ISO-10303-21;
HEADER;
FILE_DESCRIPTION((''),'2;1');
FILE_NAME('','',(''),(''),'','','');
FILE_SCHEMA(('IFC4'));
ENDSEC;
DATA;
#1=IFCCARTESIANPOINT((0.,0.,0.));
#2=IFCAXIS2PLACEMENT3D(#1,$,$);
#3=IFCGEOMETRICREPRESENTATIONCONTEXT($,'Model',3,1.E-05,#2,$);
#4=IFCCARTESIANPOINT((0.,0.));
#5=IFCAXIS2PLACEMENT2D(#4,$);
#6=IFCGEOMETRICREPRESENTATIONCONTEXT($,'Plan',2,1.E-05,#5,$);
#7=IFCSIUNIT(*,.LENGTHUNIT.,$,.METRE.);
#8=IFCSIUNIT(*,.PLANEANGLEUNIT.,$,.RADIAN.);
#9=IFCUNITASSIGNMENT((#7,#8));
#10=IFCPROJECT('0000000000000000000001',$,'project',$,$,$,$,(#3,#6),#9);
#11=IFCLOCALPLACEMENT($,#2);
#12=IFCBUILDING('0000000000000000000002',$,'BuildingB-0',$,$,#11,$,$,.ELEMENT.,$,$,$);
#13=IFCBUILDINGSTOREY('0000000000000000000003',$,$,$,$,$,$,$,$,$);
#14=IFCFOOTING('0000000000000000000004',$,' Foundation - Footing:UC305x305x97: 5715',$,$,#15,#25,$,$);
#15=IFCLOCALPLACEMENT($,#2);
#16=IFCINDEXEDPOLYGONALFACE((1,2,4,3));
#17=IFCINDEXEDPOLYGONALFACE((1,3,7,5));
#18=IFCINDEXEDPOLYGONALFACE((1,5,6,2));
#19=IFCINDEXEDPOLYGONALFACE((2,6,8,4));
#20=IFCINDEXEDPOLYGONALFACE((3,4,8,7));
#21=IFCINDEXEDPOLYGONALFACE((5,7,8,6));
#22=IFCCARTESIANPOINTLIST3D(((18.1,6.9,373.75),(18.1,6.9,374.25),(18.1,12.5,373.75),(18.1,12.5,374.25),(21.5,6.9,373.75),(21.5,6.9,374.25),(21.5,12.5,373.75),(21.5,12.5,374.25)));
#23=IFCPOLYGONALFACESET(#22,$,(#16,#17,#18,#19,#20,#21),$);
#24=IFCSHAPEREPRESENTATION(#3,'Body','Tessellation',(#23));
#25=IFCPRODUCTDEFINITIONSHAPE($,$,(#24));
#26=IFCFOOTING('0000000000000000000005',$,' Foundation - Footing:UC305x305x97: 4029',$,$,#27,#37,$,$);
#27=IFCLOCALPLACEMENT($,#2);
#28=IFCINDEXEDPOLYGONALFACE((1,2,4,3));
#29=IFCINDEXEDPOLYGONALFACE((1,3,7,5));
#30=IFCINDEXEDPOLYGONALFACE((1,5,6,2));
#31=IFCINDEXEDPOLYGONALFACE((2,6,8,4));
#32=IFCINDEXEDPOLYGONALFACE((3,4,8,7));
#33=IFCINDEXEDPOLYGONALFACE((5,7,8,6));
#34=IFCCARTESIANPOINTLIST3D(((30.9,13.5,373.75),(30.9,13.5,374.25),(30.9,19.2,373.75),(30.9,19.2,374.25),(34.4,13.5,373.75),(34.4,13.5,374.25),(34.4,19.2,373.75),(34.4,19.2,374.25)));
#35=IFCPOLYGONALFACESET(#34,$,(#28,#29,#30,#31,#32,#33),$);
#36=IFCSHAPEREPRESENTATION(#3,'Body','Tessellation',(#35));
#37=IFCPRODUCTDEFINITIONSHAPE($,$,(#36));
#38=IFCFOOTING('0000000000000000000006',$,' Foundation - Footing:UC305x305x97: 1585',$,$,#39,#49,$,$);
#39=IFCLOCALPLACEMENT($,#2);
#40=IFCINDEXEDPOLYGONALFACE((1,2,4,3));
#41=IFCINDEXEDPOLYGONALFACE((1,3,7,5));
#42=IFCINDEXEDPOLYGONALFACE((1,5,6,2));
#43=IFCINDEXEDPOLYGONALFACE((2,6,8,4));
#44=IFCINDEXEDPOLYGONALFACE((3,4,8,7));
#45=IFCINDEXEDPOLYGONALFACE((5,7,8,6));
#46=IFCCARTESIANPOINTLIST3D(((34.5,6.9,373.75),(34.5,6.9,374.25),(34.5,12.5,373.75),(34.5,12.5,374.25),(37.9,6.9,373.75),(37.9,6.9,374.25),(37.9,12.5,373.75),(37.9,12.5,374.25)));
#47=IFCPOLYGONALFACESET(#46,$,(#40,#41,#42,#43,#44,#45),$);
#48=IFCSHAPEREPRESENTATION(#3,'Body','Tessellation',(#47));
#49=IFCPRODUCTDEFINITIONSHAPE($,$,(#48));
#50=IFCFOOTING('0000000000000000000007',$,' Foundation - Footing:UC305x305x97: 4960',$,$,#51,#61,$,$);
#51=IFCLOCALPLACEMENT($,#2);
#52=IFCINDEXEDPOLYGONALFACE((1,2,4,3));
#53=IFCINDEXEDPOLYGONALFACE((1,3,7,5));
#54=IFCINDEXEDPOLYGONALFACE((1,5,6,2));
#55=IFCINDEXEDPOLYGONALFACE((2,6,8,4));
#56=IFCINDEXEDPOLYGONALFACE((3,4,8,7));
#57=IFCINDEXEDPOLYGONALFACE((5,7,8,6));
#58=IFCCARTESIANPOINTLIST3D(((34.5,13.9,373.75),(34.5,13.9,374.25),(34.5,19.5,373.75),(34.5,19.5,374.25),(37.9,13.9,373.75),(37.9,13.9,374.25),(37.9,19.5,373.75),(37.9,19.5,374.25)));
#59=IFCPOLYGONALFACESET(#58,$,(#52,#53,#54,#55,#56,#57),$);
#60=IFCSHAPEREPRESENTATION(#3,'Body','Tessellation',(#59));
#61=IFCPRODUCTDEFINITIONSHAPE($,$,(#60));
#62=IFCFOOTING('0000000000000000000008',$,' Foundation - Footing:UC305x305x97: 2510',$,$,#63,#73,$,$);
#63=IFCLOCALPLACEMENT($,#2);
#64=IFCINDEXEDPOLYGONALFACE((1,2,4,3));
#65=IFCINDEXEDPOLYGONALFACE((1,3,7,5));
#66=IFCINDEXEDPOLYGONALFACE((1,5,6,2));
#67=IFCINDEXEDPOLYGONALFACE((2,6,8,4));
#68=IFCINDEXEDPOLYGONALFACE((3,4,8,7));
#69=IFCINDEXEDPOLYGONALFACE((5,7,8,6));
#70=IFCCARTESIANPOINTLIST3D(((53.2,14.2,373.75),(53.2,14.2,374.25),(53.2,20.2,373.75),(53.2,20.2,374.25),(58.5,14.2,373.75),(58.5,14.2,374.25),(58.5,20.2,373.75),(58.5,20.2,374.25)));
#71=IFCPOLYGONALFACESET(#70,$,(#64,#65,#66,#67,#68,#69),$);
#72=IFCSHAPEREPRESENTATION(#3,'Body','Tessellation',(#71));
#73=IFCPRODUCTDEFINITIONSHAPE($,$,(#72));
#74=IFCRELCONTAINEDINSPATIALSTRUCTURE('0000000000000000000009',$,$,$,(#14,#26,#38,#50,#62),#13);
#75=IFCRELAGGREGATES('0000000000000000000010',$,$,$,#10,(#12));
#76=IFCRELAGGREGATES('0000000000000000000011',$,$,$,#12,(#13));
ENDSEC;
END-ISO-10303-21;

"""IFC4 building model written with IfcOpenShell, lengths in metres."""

from ifc_helpers import new_model, si_unit, origin, origin_2d, place, context, project, spatial, polyline, outline, extrude, element, save


model = new_model("IFC4")

# Units and contexts
model_context = context("Model", 3, precision=1e-05, world=origin())
plan_context = context("Plan", 2, precision=1e-05, world=origin_2d())
ifc_project = project(units=[si_unit("LENGTHUNIT", "METRE"), si_unit("PLANEANGLEUNIT", "RADIAN")], contexts=[model_context, plan_context])

# Building, storey
building_placement = place(None, origin())
building = spatial("IfcBuilding", under=ifc_project, at=building_placement, Name="BuildingB-0", CompositionType="ELEMENT")
storey = spatial("IfcBuildingStorey", under=building)

# Footings
element("IfcFooting", 1, inside=storey, Name=" Foundation - Footing:UC305x305x97: 5715", context=model_context, shape_type="SweptSolid", body=[
    extrude(outline(polyline([(21.5, 12.5, 373.75), (18.1, 12.5, 373.75), (18.1, 6.9, 373.75), (21.5, 6.9, 373.75), (21.5, 12.5, 373.75)])), None, (0.0, 0.0, 1.0), 0.5),
])
element("IfcFooting", 2, inside=storey, Name=" Foundation - Footing:UC305x305x97: 4029", context=model_context, shape_type="SweptSolid", body=[
    extrude(outline(polyline([(34.4, 19.2, 373.75), (30.9, 19.2, 373.75), (30.9, 13.5, 373.75), (34.4, 13.5, 373.75), (34.4, 19.2, 373.75)])), None, (0.0, 0.0, 1.0), 0.5),
])
element("IfcFooting", 3, inside=storey, Name=" Foundation - Footing:UC305x305x97: 1585", context=model_context, shape_type="SweptSolid", body=[
    extrude(outline(polyline([(37.9, 12.5, 373.75), (34.5, 12.5, 373.75), (34.5, 6.9, 373.75), (37.9, 6.9, 373.75), (37.9, 12.5, 373.75)])), None, (0.0, 0.0, 1.0), 0.5),
])
element("IfcFooting", 4, inside=storey, Name=" Foundation - Footing:UC305x305x97: 4960", context=model_context, shape_type="SweptSolid", body=[
    extrude(outline(polyline([(37.9, 19.5, 373.75), (34.5, 19.5, 373.75), (34.5, 13.9, 373.75), (37.9, 13.9, 373.75), (37.9, 19.5, 373.75)])), None, (0.0, 0.0, 1.0), 0.5),
])
element("IfcFooting", 5, inside=storey, Name=" Foundation - Footing:UC305x305x97: 2510", context=model_context, shape_type="SweptSolid", body=[
    extrude(outline(polyline([(58.5, 20.2, 373.75), (53.2, 20.2, 373.75), (53.2, 14.2, 373.75), (58.5, 14.2, 373.75), (58.5, 20.2, 373.75)])), None, (0.0, 0.0, 1.0), 0.5),
])

save(model, "model.ifc")
